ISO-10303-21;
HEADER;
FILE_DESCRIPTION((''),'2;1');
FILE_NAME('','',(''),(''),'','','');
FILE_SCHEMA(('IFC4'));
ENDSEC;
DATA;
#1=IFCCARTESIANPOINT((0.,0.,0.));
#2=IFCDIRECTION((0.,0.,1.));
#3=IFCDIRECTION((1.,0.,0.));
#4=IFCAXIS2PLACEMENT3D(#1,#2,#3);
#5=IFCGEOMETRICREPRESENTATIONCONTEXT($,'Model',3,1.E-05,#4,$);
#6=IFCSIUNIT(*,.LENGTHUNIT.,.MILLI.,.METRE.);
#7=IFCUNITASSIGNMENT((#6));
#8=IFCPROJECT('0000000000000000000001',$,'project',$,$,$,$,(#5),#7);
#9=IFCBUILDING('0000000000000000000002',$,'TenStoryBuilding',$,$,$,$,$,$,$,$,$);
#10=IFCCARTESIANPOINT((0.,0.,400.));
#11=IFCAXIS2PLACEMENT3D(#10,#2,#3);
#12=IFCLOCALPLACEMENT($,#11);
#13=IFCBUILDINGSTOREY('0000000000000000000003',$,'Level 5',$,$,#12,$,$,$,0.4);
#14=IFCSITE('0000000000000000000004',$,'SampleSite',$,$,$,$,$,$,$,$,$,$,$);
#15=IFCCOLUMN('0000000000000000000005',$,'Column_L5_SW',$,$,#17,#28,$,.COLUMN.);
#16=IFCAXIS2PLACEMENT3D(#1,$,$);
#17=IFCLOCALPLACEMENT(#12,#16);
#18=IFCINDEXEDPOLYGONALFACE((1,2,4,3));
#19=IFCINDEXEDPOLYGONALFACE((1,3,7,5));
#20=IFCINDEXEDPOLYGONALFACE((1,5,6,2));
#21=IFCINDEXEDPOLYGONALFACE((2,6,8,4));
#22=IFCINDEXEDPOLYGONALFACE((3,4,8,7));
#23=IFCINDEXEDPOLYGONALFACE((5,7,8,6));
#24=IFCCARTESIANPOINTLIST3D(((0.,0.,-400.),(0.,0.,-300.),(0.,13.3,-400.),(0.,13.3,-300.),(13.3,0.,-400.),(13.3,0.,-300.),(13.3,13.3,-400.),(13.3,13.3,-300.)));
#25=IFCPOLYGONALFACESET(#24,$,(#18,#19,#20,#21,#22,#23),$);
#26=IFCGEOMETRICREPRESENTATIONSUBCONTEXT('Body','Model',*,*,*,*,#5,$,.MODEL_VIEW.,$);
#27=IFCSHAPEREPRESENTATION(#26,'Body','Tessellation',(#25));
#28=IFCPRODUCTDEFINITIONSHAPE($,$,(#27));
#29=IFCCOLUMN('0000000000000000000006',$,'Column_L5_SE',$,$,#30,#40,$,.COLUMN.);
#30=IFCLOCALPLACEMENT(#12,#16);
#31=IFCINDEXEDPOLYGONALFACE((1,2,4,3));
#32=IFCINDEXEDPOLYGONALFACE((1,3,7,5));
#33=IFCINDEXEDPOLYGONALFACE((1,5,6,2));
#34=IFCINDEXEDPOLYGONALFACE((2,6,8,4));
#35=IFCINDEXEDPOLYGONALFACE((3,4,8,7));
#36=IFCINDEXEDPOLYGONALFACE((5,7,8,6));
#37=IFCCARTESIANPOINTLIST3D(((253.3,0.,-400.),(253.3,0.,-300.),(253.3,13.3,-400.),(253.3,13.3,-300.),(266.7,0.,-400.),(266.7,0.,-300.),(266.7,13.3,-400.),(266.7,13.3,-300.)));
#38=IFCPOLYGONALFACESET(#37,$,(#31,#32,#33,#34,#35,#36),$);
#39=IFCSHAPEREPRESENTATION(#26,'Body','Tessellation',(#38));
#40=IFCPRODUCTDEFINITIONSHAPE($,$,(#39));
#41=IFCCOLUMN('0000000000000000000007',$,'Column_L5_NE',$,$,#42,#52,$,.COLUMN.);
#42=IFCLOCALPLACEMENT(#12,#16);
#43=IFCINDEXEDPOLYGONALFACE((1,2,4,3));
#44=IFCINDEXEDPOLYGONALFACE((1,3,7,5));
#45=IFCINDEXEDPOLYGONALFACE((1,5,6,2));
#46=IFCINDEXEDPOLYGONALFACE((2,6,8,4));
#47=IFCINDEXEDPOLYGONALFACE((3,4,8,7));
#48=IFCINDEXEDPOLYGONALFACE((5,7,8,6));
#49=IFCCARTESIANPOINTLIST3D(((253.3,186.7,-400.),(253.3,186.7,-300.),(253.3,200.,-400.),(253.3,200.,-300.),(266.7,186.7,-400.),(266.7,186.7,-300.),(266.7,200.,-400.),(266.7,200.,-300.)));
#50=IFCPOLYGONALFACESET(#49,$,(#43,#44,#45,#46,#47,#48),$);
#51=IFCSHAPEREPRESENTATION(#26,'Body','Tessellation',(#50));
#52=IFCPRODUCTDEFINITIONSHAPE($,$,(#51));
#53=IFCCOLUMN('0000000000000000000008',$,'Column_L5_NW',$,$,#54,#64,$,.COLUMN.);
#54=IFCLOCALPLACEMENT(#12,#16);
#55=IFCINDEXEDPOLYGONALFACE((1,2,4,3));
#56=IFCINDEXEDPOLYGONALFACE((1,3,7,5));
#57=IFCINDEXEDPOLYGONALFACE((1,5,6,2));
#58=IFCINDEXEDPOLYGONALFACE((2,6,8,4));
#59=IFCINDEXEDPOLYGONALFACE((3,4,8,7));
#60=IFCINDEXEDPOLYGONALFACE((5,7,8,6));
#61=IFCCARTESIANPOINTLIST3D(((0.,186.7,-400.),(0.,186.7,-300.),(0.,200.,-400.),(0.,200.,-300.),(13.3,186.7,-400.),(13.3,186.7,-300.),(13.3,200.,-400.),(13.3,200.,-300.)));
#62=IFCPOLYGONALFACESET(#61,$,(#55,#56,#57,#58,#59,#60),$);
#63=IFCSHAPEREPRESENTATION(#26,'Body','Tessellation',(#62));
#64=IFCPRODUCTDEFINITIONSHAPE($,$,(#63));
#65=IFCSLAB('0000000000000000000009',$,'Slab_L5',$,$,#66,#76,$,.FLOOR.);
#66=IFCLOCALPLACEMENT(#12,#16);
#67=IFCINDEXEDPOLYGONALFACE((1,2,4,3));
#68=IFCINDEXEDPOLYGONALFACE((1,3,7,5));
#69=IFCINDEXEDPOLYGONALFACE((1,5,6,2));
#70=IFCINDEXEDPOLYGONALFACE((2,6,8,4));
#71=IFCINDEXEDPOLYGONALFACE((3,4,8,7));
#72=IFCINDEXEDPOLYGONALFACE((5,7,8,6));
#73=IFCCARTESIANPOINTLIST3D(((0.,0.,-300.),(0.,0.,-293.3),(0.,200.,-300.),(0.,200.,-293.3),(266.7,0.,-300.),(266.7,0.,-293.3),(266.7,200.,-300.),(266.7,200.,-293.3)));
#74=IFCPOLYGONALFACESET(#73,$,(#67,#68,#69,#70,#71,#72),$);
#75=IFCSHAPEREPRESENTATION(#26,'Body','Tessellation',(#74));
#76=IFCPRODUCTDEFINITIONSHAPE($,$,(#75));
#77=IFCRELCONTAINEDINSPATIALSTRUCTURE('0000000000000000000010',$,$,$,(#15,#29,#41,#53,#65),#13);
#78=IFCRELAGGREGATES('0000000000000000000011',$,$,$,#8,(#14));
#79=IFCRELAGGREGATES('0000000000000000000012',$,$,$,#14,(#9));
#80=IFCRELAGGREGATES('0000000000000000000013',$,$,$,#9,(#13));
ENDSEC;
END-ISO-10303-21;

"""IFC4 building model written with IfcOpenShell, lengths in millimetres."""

from ifc_helpers import new_model, si_unit, frame, origin_with_axes, origin_2d, place, context, subcontext, project, spatial, indexed_curve, rectangle, outline, extrude, element, save


model = new_model("IFC4")

# Units and contexts
model_context = context("Model", 3, precision=1e-05, world=origin_with_axes())
body_context = subcontext(model_context, "Body", "Model", "MODEL_VIEW")
ifc_project = project(units=[si_unit("LENGTHUNIT", "METRE", prefix="MILLI")], contexts=[model_context])

# Site, building, storey
site = spatial("IfcSite", under=ifc_project, Name="SampleSite")
building = spatial("IfcBuilding", under=site, Name="TenStoryBuilding")
storey_placement = place(None, frame((0.0, 0.0, 400.0), z_axis=(0.0, 0.0, 1.0), x_axis=(1.0, 0.0, 0.0)))
storey = spatial("IfcBuildingStorey", under=building, at=storey_placement, Name="Level 5", Elevation=0.4)

# Columns
for number, where, z_axis, x_axis, name in (
    (1, (6.7, 6.7, -400.0), (0.0, 0.0, 1.0), (1.0, 0.0, 0.0), "Column_L5_SW"),
    (2, (260.0, 6.7, -400.0), (0.0, 0.0, 1.0), (1.0, 0.0, 0.0), "Column_L5_SE"),
    (3, (260.0, 193.3, -400.0), (0.0, 0.0, 1.0), (1.0, 0.0, 0.0), "Column_L5_NE"),
    (4, (6.7, 193.3, -400.0), (0.0, 0.0, 1.0), (1.0, 0.0, 0.0), "Column_L5_NW"),
):
    element("IfcColumn", number, at=place(storey_placement, frame(where, z_axis=z_axis, x_axis=x_axis)), inside=storey, Name=name, PredefinedType="COLUMN", context=body_context, shape_type="SweptSolid", body=[
        extrude(rectangle(XDim=13.3, YDim=13.3, at=origin_2d()), origin_with_axes(), (0.0, 0.0, 1.0), 100.0),
    ])

# Slab
slab_placement = place(storey_placement, frame((0.0, 0.0, -300.0), z_axis=(0.0, 0.0, 1.0), x_axis=(1.0, 0.0, 0.0)))
element("IfcSlab", 5, at=slab_placement, inside=storey, Name="Slab_L5", PredefinedType="FLOOR", context=body_context, shape_type="SweptSolid", body=[
    extrude(outline(indexed_curve([(0.0, 0.0), (266.7, 0.0), (266.7, 200.0), (0.0, 200.0), (0.0, 0.0)])), None, (0.0, 0.0, 1.0), 6.7),
])

save(model, "model.ifc")
